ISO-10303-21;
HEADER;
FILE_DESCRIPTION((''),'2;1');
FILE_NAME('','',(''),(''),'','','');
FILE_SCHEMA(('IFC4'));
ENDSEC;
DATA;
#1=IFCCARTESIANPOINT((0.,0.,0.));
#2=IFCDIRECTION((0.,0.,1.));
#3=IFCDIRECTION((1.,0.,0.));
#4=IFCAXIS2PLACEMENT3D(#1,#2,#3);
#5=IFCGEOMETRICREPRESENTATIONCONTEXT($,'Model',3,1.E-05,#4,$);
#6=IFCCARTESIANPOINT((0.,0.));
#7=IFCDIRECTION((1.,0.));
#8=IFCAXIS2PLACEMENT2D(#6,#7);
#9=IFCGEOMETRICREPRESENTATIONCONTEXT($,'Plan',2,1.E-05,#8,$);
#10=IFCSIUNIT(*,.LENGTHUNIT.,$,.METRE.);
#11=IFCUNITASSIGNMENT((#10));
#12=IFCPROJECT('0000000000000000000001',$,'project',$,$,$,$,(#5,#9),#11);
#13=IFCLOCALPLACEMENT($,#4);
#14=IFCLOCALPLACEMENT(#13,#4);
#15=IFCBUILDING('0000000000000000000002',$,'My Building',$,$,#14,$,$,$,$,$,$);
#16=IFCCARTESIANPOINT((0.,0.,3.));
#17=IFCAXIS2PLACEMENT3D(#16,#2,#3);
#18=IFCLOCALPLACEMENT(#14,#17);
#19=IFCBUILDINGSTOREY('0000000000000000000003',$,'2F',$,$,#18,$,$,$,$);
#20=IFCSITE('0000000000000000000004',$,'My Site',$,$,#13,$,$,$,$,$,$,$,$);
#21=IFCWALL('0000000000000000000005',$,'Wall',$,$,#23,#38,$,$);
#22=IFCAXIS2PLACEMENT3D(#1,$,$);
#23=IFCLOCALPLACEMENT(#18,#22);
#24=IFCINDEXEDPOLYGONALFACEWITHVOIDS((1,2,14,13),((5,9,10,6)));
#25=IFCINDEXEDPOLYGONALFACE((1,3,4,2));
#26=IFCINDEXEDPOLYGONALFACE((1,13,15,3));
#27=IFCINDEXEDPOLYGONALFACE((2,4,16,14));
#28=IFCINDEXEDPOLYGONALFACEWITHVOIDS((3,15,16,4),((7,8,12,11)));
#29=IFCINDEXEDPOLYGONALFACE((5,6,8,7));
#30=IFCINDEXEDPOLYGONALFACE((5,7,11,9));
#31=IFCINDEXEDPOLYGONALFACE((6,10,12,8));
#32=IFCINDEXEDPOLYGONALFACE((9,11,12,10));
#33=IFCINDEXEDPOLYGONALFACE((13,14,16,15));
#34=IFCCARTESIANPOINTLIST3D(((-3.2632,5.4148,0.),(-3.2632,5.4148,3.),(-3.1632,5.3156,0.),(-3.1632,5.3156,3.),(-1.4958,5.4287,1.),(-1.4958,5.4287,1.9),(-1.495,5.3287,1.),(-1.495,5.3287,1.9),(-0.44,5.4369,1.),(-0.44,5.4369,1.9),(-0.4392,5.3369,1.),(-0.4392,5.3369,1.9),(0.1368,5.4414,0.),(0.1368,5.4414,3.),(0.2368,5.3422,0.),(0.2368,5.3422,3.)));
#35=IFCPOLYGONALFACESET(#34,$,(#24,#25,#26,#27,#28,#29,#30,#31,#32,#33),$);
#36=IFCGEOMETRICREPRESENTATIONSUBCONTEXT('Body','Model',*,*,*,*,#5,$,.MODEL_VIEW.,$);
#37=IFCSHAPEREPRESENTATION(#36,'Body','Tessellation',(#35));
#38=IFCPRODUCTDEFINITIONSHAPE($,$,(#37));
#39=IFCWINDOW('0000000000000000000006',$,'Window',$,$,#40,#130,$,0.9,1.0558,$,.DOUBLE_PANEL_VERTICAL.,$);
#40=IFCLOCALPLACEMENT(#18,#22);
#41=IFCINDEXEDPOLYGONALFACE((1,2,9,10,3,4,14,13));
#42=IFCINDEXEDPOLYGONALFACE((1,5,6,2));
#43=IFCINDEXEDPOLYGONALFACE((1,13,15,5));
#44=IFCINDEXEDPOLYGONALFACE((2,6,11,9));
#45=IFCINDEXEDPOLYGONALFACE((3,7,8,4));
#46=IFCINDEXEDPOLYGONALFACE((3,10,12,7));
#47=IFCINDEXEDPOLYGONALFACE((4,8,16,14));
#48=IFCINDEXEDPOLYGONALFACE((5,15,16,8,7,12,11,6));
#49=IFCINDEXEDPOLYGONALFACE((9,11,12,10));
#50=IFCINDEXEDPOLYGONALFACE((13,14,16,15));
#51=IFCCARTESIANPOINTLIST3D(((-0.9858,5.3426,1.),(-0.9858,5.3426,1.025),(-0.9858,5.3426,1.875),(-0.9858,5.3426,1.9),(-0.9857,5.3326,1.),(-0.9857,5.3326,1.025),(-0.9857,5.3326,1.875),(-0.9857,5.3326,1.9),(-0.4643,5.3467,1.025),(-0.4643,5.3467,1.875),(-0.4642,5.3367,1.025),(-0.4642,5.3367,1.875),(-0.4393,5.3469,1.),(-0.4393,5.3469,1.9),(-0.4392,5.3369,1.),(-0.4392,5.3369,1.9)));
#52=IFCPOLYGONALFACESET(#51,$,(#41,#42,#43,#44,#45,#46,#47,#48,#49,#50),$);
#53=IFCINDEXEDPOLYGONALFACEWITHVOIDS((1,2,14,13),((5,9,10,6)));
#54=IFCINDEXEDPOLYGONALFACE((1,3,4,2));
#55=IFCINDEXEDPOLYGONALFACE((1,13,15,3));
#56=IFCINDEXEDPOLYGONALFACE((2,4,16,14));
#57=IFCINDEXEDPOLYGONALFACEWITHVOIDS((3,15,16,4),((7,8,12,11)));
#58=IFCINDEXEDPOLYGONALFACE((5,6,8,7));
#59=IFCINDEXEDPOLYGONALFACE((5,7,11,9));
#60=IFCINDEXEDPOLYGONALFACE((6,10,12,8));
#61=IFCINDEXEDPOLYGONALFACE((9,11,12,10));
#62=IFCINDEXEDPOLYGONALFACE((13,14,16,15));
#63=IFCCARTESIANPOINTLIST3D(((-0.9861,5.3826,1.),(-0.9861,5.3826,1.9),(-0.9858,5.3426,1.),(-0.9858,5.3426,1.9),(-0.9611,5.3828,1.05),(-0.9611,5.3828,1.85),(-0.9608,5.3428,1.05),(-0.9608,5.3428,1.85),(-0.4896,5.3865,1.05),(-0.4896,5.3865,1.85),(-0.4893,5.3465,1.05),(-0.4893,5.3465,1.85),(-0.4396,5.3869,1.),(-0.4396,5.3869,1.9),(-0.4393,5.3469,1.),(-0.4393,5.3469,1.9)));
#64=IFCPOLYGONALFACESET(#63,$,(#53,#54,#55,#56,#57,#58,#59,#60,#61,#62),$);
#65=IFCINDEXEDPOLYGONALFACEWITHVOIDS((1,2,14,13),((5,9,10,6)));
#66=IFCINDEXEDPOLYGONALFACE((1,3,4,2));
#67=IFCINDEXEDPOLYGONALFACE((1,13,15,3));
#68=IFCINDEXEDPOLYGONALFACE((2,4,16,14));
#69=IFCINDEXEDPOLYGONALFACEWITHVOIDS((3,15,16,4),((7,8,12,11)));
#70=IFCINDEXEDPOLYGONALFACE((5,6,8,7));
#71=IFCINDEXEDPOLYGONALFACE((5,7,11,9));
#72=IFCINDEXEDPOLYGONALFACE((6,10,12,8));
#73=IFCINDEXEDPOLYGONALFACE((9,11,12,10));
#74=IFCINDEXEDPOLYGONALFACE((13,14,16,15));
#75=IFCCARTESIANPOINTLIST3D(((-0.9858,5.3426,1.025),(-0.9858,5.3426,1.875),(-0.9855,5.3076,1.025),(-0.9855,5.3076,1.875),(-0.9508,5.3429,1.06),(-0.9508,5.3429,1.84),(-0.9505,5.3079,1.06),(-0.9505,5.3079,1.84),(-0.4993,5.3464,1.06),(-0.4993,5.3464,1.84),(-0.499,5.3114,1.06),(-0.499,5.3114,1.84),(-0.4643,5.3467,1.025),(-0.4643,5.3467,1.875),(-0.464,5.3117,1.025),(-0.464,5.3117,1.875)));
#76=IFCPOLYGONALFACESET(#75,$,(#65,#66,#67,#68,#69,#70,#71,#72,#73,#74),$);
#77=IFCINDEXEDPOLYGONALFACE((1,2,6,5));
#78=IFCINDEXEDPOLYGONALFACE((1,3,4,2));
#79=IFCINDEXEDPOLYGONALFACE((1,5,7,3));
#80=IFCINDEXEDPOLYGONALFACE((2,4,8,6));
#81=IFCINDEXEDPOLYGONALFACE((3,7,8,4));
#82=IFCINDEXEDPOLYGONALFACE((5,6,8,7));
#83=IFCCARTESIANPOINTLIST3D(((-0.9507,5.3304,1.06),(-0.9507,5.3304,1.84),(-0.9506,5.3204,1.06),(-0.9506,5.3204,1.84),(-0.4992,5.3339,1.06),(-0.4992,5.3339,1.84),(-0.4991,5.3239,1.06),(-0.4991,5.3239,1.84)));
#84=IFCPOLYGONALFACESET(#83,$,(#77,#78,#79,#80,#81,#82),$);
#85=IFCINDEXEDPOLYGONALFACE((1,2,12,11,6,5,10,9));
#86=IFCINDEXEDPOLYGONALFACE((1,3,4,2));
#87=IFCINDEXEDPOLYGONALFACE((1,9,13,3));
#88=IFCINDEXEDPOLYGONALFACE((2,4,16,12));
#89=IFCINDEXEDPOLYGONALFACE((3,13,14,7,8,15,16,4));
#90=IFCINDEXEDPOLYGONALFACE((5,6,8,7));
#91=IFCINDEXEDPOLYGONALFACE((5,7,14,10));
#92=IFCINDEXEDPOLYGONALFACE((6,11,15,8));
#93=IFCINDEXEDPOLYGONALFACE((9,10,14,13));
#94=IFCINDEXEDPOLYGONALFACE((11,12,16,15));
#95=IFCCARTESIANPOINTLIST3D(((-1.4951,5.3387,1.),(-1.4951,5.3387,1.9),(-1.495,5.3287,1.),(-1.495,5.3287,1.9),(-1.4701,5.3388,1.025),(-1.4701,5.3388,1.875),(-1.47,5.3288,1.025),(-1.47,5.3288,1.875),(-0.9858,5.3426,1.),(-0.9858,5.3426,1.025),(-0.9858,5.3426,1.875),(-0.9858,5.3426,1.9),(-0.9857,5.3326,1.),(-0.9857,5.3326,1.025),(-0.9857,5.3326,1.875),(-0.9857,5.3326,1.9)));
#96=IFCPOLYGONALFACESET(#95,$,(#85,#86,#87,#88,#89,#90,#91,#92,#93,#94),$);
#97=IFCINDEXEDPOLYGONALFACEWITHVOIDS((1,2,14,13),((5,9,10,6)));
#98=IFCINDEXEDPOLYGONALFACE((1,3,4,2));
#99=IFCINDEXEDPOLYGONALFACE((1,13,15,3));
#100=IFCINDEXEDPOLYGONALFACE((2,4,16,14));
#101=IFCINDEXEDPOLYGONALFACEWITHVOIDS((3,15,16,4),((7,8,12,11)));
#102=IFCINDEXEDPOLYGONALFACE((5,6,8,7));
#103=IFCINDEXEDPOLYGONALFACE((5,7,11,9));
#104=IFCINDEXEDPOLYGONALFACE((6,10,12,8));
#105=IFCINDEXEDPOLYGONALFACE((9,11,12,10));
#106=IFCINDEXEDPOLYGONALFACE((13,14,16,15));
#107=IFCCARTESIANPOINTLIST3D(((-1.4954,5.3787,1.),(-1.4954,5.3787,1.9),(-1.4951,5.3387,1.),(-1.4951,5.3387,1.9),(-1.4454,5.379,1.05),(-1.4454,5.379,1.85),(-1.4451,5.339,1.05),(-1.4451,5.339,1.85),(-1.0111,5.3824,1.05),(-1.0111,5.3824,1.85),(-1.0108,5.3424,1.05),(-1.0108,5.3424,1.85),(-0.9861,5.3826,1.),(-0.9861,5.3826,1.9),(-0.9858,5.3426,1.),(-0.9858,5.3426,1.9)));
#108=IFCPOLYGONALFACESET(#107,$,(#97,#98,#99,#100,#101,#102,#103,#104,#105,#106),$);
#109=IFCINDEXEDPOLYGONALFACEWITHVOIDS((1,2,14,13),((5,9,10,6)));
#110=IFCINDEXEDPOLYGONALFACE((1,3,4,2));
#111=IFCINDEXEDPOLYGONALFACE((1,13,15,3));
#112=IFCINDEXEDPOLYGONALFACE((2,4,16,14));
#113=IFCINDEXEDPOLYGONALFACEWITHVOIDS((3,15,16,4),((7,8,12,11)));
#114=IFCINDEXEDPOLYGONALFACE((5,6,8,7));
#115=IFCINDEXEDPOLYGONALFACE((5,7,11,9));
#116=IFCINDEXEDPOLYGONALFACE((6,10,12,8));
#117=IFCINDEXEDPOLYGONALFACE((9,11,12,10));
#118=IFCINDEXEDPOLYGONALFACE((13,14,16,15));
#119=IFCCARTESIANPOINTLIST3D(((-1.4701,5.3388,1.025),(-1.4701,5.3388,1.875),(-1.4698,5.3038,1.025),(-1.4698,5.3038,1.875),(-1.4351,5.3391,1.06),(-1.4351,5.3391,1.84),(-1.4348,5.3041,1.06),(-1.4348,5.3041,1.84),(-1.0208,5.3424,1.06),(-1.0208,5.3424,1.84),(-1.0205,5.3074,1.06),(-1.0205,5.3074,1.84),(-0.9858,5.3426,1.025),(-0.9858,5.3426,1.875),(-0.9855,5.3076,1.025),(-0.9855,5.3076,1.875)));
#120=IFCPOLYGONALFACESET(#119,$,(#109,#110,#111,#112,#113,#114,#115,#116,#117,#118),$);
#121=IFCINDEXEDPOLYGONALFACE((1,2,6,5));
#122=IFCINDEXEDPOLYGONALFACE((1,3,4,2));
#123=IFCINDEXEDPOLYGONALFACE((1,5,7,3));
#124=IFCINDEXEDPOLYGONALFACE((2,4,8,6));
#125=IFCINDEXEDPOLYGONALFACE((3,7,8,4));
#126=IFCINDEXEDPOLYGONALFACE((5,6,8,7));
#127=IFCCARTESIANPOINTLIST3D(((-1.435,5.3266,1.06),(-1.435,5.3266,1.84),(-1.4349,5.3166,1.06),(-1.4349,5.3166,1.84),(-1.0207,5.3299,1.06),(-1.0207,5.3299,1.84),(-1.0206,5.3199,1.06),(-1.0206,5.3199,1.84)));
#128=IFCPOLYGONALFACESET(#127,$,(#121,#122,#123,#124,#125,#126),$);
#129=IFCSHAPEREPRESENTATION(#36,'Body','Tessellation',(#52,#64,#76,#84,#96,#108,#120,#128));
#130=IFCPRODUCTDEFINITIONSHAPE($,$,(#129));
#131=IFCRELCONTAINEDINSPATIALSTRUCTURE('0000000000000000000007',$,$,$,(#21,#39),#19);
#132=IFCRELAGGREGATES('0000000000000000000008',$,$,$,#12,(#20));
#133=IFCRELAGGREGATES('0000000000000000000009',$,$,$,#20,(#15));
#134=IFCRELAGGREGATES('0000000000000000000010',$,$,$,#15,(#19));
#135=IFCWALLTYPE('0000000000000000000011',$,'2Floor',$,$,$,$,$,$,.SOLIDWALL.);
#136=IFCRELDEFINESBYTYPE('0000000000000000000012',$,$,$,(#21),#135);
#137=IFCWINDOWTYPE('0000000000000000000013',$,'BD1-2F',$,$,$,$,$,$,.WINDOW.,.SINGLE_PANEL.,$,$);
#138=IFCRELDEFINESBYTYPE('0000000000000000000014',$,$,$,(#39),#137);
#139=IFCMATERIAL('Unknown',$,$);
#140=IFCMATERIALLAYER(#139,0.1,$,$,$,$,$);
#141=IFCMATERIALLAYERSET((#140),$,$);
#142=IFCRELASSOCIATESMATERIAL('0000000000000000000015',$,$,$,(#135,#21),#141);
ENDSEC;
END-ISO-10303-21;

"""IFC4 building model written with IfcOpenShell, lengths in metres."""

from ifc_helpers import new_model, entity, si_unit, frame, origin_with_axes, origin_2d_with_axis, place, context, subcontext, project, spatial, line, indexed_curve, outline, extrude, shape, source, transform, mapped, material, layer, layer_set, layer_usage, type_object, type_shapes, element, fill, save


model = new_model("IFC4")

# Units and contexts
model_context = context("Model", 3, precision=1e-05, world=origin_with_axes())
plan_context = context("Plan", 2, precision=1e-05, world=origin_2d_with_axis())
body_context_1 = subcontext(model_context, "Body", "Model", "MODEL_VIEW")
body_context_2 = subcontext(plan_context, "Body", "Plan", "PLAN_VIEW")
ifc_project = project(units=[si_unit("LENGTHUNIT", "METRE")], contexts=[model_context, plan_context])

# Site, building, storey
site_placement = place(None, origin_with_axes())
site = spatial("IfcSite", under=ifc_project, at=site_placement, Name="My Site")
building_placement = place(site_placement, origin_with_axes())
building = spatial("IfcBuilding", under=site, at=building_placement, Name="My Building")
storey_placement = place(building_placement, frame((0.0, 0.0, 3.0), z_axis=(0.0, 0.0, 1.0), x_axis=(1.0, 0.0, 0.0)))
storey = spatial("IfcBuildingStorey", under=building, at=storey_placement, Name="2F")

# Shared definitions
ifc_material = material(Name="Unknown")

# Shared definitions
ifc_layer_1 = layer(ifc_material, 0.1)
ifc_layer_set_1 = layer_set([ifc_layer_1])
wall_type = type_object("IfcWallType", Name="2Floor", PredefinedType="SOLIDWALL", material=ifc_layer_set_1)

# Wall, opening, window
ifc_layer_usage_1 = layer_usage(ifc_layer_set_1, "AXIS2", "POSITIVE", 0.0)
wall_1_placement = place(storey_placement, frame((0.1368, 5.4414, 0.0), z_axis=(0.0, 0.0, 1.0), x_axis=(-0.999969, -0.007813, 0.0)))
wall_1 = element("IfcWall", 1, at=wall_1_placement, inside=storey, type_object=wall_type, material=ifc_layer_usage_1, Name="Wall", context=body_context_1, shape_type="SweptSolid", body=[
    extrude(outline(indexed_curve([(0.0, 0.0), (-0.0992, 0.1), (3.3009, 0.1), (3.4001, 0.0)], segments=[line(1, 2, 3, 4, 1)])), origin_with_axes(), (0.0, 0.0, 1.0), 3.0),
])
shared_shape_1 = source(origin_with_axes(), body_context_1, "Body", "SweptSolid", [
    extrude(outline(indexed_curve([(0.0, 0.0), (1.0558, 0.0), (1.0558, 0.9), (0.0, 0.9)], segments=[line(1, 2, 3, 4, 1)])), frame((0.0, -0.6, 0.0), z_axis=(0.0, -1.0, 0.0), x_axis=(1.0, 0.0, 0.0)), (0.0, 0.0, -1.0), 1.2),
])
opening_1_placement = place(wall_1_placement, frame((0.5768, 0.0, 1.0), z_axis=(0.0, 0.0, 1.0), x_axis=(1.0, 0.0, 0.0)))
opening_1 = element("IfcOpeningElement", 2, at=opening_1_placement, cuts=wall_1, PredefinedType="OPENING", context=body_context_1, shape_type="MappedRepresentation", body=[
    mapped(shared_shape_1, transform((0.0, 0.0, 0.0), x_axis=(1.0, 0.0, 0.0), y_axis=(0.0, 1.0, 0.0), z_axis=(0.0, 0.0, 1.0), scale=1.0)),
])
window_type_1 = type_object("IfcWindowType", Name="BD1-2F", PartitioningType="SINGLE_PANEL", PredefinedType="WINDOW")
shared_shape_2 = source(origin_with_axes(), body_context_1, "Body", "SweptSolid", [
    extrude(outline(indexed_curve([(0.5465, 0.0), (0.0, 0.0), (0.0, 0.9), (0.5465, 0.9), (0.5465, 0.875), (0.025, 0.875), (0.025, 0.025), (0.5465, 0.025)], segments=[line(1, 2, 3, 4, 5, 6, 7, 8, 1)])), frame((0.0, 0.09, 0.0), z_axis=(0.0, -1.0, 0.0), x_axis=(1.0, 0.0, 0.0)), (0.0, 0.0, -1.0), 0.01),
    extrude(outline(indexed_curve([(0.0, 0.0), (0.5465, 0.0), (0.5465, 0.9), (0.0, 0.9)], segments=[line(1, 2, 3, 4, 1)]), holes=[indexed_curve([(0.05, 0.05), (0.5215, 0.05), (0.5215, 0.85), (0.05, 0.85)], segments=[line(1, 2, 3, 4, 1)])]), frame((0.0, 0.05, 0.0), z_axis=(0.0, -1.0, 0.0), x_axis=(1.0, 0.0, 0.0)), (0.0, 0.0, -1.0), 0.04),
    extrude(outline(indexed_curve([(0.0, 0.0), (0.5215, 0.0), (0.5215, 0.85), (0.0, 0.85)], segments=[line(1, 2, 3, 4, 1)]), holes=[indexed_curve([(0.035, 0.035), (0.4865, 0.035), (0.4865, 0.815), (0.035, 0.815)], segments=[line(1, 2, 3, 4, 1)])]), frame((0.025, 0.09, 0.025), z_axis=(0.0, -1.0, 0.0), x_axis=(1.0, 0.0, 0.0)), (0.0, 0.0, -1.0), 0.035),
    extrude(outline(indexed_curve([(0.035, 0.035), (0.4865, 0.035), (0.4865, 0.815), (0.035, 0.815)], segments=[line(1, 2, 3, 4, 1)])), frame((0.025, 0.1025, 0.025), z_axis=(0.0, -1.0, 0.0), x_axis=(1.0, 0.0, 0.0)), (0.0, 0.0, -1.0), 0.01),
    extrude(outline(indexed_curve([(0.0, 0.9), (0.5094, 0.9), (0.5094, 0.0), (0.0, 0.0), (0.0, 0.025), (0.4844, 0.025), (0.4844, 0.875), (0.0, 0.875)], segments=[line(1, 2, 3, 4, 5, 6, 7, 8, 1)])), frame((0.5465, 0.09, 0.0), z_axis=(0.0, -1.0, 0.0), x_axis=(1.0, 0.0, 0.0)), (0.0, 0.0, -1.0), 0.01),
    extrude(outline(indexed_curve([(0.0, 0.0), (0.5094, 0.0), (0.5094, 0.9), (0.0, 0.9)], segments=[line(1, 2, 3, 4, 1)]), holes=[indexed_curve([(0.025, 0.05), (0.4594, 0.05), (0.4594, 0.85), (0.025, 0.85)], segments=[line(1, 2, 3, 4, 1)])]), frame((0.5465, 0.05, 0.0), z_axis=(0.0, -1.0, 0.0), x_axis=(1.0, 0.0, 0.0)), (0.0, 0.0, -1.0), 0.04),
    extrude(outline(indexed_curve([(0.0, 0.0), (0.4844, 0.0), (0.4844, 0.85), (0.0, 0.85)], segments=[line(1, 2, 3, 4, 1)]), holes=[indexed_curve([(0.035, 0.035), (0.4494, 0.035), (0.4494, 0.815), (0.035, 0.815)], segments=[line(1, 2, 3, 4, 1)])]), frame((0.5465, 0.09, 0.025), z_axis=(0.0, -1.0, 0.0), x_axis=(1.0, 0.0, 0.0)), (0.0, 0.0, -1.0), 0.035),
    extrude(outline(indexed_curve([(0.035, 0.035), (0.4494, 0.035), (0.4494, 0.815), (0.035, 0.815)], segments=[line(1, 2, 3, 4, 1)])), frame((0.5465, 0.1025, 0.025), z_axis=(0.0, -1.0, 0.0), x_axis=(1.0, 0.0, 0.0)), (0.0, 0.0, -1.0), 0.01),
])
shared_shape_3 = source(origin_with_axes(), body_context_2, "Body", "Curve2D", [
    entity("IfcIndexedPolyCurve", entity("IfcCartesianPointList2D", [[0.05, 0.05], [0.5215, 0.05]])),
    entity("IfcIndexedPolyCurve", entity("IfcCartesianPointList2D", [[0.0, 0.1], [0.025, 0.1], [0.025, 0.09], [0.05, 0.09], [0.05, 0.05], [0.0, 0.05]]), [entity("IfcLineIndex", [1, 2, 3, 4, 5, 6, 1])]),
    entity("IfcIndexedPolyCurve", entity("IfcCartesianPointList2D", [[0.5465, 0.1], [0.5465, 0.1], [0.5465, 0.09], [0.5215, 0.09], [0.5215, 0.05], [0.5465, 0.05]])),
    entity("IfcIndexedPolyCurve", entity("IfcCartesianPointList2D", [[0.025, 0.09], [0.06, 0.09], [0.06, 0.125], [0.025, 0.125]]), [entity("IfcLineIndex", [1, 2, 3, 4, 1])]),
    entity("IfcIndexedPolyCurve", entity("IfcCartesianPointList2D", [[0.5465, 0.09], [0.5115, 0.09], [0.5115, 0.125], [0.5465, 0.125]]), [entity("IfcLineIndex", [1, 2, 3, 4, 1])]),
    entity("IfcIndexedPolyCurve", entity("IfcCartesianPointList2D", [[0.06, 0.09], [0.5115, 0.09]])),
    entity("IfcIndexedPolyCurve", entity("IfcCartesianPointList2D", [[0.06, 0.125], [0.5115, 0.125]])),
    entity("IfcIndexedPolyCurve", entity("IfcCartesianPointList2D", [[0.06, 0.1075], [0.5115, 0.1075]])),
    entity("IfcIndexedPolyCurve", entity("IfcCartesianPointList2D", [[0.5715, 0.05], [1.0058, 0.05]])),
    entity("IfcIndexedPolyCurve", entity("IfcCartesianPointList2D", [[0.5465, 0.1], [0.5465, 0.1], [0.5465, 0.09], [0.5715, 0.09], [0.5715, 0.05], [0.5465, 0.05]])),
    entity("IfcIndexedPolyCurve", entity("IfcCartesianPointList2D", [[1.0558, 0.1], [1.0308, 0.1], [1.0308, 0.09], [1.0058, 0.09], [1.0058, 0.05], [1.0558, 0.05]]), [entity("IfcLineIndex", [1, 2, 3, 4, 5, 6, 1])]),
    entity("IfcIndexedPolyCurve", entity("IfcCartesianPointList2D", [[0.5465, 0.09], [0.5815, 0.09], [0.5815, 0.125], [0.5465, 0.125]]), [entity("IfcLineIndex", [1, 2, 3, 4, 1])]),
    entity("IfcIndexedPolyCurve", entity("IfcCartesianPointList2D", [[1.0308, 0.09], [0.9958, 0.09], [0.9958, 0.125], [1.0308, 0.125]]), [entity("IfcLineIndex", [1, 2, 3, 4, 1])]),
    entity("IfcIndexedPolyCurve", entity("IfcCartesianPointList2D", [[0.5815, 0.09], [0.9958, 0.09]])),
    entity("IfcIndexedPolyCurve", entity("IfcCartesianPointList2D", [[0.5815, 0.125], [0.9958, 0.125]])),
    entity("IfcIndexedPolyCurve", entity("IfcCartesianPointList2D", [[0.5815, 0.1075], [0.9958, 0.1075]])),
])
type_shapes(window_type_1, [shared_shape_2, shared_shape_3])
window_1_placement = place(opening_1_placement, frame((0.0, 0.0, 0.0), z_axis=(0.0, 0.0, 1.0), x_axis=(1.0, 0.0, 0.0)))
window_1 = element("IfcWindow", 3, at=window_1_placement, inside=storey, type_object=window_type_1, Name="Window", OverallHeight=0.9, OverallWidth=1.0558, PartitioningType="DOUBLE_PANEL_VERTICAL", shapes=[
    shape(body_context_1, "Body", "MappedRepresentation", [mapped(shared_shape_2, transform((0.0, 0.0, 0.0), x_axis=(1.0, 0.0, 0.0), y_axis=(0.0, 1.0, 0.0), z_axis=(0.0, 0.0, 1.0), scale=1.0))]),
    shape(body_context_2, "Body", "MappedRepresentation", [mapped(shared_shape_3, transform((0.0, 0.0, 0.0), x_axis=(1.0, 0.0, 0.0), y_axis=(0.0, 1.0, 0.0), z_axis=(0.0, 0.0, 1.0), scale=1.0))]),
])
fill(opening_1, window_1)

save(model, "model.ifc")
